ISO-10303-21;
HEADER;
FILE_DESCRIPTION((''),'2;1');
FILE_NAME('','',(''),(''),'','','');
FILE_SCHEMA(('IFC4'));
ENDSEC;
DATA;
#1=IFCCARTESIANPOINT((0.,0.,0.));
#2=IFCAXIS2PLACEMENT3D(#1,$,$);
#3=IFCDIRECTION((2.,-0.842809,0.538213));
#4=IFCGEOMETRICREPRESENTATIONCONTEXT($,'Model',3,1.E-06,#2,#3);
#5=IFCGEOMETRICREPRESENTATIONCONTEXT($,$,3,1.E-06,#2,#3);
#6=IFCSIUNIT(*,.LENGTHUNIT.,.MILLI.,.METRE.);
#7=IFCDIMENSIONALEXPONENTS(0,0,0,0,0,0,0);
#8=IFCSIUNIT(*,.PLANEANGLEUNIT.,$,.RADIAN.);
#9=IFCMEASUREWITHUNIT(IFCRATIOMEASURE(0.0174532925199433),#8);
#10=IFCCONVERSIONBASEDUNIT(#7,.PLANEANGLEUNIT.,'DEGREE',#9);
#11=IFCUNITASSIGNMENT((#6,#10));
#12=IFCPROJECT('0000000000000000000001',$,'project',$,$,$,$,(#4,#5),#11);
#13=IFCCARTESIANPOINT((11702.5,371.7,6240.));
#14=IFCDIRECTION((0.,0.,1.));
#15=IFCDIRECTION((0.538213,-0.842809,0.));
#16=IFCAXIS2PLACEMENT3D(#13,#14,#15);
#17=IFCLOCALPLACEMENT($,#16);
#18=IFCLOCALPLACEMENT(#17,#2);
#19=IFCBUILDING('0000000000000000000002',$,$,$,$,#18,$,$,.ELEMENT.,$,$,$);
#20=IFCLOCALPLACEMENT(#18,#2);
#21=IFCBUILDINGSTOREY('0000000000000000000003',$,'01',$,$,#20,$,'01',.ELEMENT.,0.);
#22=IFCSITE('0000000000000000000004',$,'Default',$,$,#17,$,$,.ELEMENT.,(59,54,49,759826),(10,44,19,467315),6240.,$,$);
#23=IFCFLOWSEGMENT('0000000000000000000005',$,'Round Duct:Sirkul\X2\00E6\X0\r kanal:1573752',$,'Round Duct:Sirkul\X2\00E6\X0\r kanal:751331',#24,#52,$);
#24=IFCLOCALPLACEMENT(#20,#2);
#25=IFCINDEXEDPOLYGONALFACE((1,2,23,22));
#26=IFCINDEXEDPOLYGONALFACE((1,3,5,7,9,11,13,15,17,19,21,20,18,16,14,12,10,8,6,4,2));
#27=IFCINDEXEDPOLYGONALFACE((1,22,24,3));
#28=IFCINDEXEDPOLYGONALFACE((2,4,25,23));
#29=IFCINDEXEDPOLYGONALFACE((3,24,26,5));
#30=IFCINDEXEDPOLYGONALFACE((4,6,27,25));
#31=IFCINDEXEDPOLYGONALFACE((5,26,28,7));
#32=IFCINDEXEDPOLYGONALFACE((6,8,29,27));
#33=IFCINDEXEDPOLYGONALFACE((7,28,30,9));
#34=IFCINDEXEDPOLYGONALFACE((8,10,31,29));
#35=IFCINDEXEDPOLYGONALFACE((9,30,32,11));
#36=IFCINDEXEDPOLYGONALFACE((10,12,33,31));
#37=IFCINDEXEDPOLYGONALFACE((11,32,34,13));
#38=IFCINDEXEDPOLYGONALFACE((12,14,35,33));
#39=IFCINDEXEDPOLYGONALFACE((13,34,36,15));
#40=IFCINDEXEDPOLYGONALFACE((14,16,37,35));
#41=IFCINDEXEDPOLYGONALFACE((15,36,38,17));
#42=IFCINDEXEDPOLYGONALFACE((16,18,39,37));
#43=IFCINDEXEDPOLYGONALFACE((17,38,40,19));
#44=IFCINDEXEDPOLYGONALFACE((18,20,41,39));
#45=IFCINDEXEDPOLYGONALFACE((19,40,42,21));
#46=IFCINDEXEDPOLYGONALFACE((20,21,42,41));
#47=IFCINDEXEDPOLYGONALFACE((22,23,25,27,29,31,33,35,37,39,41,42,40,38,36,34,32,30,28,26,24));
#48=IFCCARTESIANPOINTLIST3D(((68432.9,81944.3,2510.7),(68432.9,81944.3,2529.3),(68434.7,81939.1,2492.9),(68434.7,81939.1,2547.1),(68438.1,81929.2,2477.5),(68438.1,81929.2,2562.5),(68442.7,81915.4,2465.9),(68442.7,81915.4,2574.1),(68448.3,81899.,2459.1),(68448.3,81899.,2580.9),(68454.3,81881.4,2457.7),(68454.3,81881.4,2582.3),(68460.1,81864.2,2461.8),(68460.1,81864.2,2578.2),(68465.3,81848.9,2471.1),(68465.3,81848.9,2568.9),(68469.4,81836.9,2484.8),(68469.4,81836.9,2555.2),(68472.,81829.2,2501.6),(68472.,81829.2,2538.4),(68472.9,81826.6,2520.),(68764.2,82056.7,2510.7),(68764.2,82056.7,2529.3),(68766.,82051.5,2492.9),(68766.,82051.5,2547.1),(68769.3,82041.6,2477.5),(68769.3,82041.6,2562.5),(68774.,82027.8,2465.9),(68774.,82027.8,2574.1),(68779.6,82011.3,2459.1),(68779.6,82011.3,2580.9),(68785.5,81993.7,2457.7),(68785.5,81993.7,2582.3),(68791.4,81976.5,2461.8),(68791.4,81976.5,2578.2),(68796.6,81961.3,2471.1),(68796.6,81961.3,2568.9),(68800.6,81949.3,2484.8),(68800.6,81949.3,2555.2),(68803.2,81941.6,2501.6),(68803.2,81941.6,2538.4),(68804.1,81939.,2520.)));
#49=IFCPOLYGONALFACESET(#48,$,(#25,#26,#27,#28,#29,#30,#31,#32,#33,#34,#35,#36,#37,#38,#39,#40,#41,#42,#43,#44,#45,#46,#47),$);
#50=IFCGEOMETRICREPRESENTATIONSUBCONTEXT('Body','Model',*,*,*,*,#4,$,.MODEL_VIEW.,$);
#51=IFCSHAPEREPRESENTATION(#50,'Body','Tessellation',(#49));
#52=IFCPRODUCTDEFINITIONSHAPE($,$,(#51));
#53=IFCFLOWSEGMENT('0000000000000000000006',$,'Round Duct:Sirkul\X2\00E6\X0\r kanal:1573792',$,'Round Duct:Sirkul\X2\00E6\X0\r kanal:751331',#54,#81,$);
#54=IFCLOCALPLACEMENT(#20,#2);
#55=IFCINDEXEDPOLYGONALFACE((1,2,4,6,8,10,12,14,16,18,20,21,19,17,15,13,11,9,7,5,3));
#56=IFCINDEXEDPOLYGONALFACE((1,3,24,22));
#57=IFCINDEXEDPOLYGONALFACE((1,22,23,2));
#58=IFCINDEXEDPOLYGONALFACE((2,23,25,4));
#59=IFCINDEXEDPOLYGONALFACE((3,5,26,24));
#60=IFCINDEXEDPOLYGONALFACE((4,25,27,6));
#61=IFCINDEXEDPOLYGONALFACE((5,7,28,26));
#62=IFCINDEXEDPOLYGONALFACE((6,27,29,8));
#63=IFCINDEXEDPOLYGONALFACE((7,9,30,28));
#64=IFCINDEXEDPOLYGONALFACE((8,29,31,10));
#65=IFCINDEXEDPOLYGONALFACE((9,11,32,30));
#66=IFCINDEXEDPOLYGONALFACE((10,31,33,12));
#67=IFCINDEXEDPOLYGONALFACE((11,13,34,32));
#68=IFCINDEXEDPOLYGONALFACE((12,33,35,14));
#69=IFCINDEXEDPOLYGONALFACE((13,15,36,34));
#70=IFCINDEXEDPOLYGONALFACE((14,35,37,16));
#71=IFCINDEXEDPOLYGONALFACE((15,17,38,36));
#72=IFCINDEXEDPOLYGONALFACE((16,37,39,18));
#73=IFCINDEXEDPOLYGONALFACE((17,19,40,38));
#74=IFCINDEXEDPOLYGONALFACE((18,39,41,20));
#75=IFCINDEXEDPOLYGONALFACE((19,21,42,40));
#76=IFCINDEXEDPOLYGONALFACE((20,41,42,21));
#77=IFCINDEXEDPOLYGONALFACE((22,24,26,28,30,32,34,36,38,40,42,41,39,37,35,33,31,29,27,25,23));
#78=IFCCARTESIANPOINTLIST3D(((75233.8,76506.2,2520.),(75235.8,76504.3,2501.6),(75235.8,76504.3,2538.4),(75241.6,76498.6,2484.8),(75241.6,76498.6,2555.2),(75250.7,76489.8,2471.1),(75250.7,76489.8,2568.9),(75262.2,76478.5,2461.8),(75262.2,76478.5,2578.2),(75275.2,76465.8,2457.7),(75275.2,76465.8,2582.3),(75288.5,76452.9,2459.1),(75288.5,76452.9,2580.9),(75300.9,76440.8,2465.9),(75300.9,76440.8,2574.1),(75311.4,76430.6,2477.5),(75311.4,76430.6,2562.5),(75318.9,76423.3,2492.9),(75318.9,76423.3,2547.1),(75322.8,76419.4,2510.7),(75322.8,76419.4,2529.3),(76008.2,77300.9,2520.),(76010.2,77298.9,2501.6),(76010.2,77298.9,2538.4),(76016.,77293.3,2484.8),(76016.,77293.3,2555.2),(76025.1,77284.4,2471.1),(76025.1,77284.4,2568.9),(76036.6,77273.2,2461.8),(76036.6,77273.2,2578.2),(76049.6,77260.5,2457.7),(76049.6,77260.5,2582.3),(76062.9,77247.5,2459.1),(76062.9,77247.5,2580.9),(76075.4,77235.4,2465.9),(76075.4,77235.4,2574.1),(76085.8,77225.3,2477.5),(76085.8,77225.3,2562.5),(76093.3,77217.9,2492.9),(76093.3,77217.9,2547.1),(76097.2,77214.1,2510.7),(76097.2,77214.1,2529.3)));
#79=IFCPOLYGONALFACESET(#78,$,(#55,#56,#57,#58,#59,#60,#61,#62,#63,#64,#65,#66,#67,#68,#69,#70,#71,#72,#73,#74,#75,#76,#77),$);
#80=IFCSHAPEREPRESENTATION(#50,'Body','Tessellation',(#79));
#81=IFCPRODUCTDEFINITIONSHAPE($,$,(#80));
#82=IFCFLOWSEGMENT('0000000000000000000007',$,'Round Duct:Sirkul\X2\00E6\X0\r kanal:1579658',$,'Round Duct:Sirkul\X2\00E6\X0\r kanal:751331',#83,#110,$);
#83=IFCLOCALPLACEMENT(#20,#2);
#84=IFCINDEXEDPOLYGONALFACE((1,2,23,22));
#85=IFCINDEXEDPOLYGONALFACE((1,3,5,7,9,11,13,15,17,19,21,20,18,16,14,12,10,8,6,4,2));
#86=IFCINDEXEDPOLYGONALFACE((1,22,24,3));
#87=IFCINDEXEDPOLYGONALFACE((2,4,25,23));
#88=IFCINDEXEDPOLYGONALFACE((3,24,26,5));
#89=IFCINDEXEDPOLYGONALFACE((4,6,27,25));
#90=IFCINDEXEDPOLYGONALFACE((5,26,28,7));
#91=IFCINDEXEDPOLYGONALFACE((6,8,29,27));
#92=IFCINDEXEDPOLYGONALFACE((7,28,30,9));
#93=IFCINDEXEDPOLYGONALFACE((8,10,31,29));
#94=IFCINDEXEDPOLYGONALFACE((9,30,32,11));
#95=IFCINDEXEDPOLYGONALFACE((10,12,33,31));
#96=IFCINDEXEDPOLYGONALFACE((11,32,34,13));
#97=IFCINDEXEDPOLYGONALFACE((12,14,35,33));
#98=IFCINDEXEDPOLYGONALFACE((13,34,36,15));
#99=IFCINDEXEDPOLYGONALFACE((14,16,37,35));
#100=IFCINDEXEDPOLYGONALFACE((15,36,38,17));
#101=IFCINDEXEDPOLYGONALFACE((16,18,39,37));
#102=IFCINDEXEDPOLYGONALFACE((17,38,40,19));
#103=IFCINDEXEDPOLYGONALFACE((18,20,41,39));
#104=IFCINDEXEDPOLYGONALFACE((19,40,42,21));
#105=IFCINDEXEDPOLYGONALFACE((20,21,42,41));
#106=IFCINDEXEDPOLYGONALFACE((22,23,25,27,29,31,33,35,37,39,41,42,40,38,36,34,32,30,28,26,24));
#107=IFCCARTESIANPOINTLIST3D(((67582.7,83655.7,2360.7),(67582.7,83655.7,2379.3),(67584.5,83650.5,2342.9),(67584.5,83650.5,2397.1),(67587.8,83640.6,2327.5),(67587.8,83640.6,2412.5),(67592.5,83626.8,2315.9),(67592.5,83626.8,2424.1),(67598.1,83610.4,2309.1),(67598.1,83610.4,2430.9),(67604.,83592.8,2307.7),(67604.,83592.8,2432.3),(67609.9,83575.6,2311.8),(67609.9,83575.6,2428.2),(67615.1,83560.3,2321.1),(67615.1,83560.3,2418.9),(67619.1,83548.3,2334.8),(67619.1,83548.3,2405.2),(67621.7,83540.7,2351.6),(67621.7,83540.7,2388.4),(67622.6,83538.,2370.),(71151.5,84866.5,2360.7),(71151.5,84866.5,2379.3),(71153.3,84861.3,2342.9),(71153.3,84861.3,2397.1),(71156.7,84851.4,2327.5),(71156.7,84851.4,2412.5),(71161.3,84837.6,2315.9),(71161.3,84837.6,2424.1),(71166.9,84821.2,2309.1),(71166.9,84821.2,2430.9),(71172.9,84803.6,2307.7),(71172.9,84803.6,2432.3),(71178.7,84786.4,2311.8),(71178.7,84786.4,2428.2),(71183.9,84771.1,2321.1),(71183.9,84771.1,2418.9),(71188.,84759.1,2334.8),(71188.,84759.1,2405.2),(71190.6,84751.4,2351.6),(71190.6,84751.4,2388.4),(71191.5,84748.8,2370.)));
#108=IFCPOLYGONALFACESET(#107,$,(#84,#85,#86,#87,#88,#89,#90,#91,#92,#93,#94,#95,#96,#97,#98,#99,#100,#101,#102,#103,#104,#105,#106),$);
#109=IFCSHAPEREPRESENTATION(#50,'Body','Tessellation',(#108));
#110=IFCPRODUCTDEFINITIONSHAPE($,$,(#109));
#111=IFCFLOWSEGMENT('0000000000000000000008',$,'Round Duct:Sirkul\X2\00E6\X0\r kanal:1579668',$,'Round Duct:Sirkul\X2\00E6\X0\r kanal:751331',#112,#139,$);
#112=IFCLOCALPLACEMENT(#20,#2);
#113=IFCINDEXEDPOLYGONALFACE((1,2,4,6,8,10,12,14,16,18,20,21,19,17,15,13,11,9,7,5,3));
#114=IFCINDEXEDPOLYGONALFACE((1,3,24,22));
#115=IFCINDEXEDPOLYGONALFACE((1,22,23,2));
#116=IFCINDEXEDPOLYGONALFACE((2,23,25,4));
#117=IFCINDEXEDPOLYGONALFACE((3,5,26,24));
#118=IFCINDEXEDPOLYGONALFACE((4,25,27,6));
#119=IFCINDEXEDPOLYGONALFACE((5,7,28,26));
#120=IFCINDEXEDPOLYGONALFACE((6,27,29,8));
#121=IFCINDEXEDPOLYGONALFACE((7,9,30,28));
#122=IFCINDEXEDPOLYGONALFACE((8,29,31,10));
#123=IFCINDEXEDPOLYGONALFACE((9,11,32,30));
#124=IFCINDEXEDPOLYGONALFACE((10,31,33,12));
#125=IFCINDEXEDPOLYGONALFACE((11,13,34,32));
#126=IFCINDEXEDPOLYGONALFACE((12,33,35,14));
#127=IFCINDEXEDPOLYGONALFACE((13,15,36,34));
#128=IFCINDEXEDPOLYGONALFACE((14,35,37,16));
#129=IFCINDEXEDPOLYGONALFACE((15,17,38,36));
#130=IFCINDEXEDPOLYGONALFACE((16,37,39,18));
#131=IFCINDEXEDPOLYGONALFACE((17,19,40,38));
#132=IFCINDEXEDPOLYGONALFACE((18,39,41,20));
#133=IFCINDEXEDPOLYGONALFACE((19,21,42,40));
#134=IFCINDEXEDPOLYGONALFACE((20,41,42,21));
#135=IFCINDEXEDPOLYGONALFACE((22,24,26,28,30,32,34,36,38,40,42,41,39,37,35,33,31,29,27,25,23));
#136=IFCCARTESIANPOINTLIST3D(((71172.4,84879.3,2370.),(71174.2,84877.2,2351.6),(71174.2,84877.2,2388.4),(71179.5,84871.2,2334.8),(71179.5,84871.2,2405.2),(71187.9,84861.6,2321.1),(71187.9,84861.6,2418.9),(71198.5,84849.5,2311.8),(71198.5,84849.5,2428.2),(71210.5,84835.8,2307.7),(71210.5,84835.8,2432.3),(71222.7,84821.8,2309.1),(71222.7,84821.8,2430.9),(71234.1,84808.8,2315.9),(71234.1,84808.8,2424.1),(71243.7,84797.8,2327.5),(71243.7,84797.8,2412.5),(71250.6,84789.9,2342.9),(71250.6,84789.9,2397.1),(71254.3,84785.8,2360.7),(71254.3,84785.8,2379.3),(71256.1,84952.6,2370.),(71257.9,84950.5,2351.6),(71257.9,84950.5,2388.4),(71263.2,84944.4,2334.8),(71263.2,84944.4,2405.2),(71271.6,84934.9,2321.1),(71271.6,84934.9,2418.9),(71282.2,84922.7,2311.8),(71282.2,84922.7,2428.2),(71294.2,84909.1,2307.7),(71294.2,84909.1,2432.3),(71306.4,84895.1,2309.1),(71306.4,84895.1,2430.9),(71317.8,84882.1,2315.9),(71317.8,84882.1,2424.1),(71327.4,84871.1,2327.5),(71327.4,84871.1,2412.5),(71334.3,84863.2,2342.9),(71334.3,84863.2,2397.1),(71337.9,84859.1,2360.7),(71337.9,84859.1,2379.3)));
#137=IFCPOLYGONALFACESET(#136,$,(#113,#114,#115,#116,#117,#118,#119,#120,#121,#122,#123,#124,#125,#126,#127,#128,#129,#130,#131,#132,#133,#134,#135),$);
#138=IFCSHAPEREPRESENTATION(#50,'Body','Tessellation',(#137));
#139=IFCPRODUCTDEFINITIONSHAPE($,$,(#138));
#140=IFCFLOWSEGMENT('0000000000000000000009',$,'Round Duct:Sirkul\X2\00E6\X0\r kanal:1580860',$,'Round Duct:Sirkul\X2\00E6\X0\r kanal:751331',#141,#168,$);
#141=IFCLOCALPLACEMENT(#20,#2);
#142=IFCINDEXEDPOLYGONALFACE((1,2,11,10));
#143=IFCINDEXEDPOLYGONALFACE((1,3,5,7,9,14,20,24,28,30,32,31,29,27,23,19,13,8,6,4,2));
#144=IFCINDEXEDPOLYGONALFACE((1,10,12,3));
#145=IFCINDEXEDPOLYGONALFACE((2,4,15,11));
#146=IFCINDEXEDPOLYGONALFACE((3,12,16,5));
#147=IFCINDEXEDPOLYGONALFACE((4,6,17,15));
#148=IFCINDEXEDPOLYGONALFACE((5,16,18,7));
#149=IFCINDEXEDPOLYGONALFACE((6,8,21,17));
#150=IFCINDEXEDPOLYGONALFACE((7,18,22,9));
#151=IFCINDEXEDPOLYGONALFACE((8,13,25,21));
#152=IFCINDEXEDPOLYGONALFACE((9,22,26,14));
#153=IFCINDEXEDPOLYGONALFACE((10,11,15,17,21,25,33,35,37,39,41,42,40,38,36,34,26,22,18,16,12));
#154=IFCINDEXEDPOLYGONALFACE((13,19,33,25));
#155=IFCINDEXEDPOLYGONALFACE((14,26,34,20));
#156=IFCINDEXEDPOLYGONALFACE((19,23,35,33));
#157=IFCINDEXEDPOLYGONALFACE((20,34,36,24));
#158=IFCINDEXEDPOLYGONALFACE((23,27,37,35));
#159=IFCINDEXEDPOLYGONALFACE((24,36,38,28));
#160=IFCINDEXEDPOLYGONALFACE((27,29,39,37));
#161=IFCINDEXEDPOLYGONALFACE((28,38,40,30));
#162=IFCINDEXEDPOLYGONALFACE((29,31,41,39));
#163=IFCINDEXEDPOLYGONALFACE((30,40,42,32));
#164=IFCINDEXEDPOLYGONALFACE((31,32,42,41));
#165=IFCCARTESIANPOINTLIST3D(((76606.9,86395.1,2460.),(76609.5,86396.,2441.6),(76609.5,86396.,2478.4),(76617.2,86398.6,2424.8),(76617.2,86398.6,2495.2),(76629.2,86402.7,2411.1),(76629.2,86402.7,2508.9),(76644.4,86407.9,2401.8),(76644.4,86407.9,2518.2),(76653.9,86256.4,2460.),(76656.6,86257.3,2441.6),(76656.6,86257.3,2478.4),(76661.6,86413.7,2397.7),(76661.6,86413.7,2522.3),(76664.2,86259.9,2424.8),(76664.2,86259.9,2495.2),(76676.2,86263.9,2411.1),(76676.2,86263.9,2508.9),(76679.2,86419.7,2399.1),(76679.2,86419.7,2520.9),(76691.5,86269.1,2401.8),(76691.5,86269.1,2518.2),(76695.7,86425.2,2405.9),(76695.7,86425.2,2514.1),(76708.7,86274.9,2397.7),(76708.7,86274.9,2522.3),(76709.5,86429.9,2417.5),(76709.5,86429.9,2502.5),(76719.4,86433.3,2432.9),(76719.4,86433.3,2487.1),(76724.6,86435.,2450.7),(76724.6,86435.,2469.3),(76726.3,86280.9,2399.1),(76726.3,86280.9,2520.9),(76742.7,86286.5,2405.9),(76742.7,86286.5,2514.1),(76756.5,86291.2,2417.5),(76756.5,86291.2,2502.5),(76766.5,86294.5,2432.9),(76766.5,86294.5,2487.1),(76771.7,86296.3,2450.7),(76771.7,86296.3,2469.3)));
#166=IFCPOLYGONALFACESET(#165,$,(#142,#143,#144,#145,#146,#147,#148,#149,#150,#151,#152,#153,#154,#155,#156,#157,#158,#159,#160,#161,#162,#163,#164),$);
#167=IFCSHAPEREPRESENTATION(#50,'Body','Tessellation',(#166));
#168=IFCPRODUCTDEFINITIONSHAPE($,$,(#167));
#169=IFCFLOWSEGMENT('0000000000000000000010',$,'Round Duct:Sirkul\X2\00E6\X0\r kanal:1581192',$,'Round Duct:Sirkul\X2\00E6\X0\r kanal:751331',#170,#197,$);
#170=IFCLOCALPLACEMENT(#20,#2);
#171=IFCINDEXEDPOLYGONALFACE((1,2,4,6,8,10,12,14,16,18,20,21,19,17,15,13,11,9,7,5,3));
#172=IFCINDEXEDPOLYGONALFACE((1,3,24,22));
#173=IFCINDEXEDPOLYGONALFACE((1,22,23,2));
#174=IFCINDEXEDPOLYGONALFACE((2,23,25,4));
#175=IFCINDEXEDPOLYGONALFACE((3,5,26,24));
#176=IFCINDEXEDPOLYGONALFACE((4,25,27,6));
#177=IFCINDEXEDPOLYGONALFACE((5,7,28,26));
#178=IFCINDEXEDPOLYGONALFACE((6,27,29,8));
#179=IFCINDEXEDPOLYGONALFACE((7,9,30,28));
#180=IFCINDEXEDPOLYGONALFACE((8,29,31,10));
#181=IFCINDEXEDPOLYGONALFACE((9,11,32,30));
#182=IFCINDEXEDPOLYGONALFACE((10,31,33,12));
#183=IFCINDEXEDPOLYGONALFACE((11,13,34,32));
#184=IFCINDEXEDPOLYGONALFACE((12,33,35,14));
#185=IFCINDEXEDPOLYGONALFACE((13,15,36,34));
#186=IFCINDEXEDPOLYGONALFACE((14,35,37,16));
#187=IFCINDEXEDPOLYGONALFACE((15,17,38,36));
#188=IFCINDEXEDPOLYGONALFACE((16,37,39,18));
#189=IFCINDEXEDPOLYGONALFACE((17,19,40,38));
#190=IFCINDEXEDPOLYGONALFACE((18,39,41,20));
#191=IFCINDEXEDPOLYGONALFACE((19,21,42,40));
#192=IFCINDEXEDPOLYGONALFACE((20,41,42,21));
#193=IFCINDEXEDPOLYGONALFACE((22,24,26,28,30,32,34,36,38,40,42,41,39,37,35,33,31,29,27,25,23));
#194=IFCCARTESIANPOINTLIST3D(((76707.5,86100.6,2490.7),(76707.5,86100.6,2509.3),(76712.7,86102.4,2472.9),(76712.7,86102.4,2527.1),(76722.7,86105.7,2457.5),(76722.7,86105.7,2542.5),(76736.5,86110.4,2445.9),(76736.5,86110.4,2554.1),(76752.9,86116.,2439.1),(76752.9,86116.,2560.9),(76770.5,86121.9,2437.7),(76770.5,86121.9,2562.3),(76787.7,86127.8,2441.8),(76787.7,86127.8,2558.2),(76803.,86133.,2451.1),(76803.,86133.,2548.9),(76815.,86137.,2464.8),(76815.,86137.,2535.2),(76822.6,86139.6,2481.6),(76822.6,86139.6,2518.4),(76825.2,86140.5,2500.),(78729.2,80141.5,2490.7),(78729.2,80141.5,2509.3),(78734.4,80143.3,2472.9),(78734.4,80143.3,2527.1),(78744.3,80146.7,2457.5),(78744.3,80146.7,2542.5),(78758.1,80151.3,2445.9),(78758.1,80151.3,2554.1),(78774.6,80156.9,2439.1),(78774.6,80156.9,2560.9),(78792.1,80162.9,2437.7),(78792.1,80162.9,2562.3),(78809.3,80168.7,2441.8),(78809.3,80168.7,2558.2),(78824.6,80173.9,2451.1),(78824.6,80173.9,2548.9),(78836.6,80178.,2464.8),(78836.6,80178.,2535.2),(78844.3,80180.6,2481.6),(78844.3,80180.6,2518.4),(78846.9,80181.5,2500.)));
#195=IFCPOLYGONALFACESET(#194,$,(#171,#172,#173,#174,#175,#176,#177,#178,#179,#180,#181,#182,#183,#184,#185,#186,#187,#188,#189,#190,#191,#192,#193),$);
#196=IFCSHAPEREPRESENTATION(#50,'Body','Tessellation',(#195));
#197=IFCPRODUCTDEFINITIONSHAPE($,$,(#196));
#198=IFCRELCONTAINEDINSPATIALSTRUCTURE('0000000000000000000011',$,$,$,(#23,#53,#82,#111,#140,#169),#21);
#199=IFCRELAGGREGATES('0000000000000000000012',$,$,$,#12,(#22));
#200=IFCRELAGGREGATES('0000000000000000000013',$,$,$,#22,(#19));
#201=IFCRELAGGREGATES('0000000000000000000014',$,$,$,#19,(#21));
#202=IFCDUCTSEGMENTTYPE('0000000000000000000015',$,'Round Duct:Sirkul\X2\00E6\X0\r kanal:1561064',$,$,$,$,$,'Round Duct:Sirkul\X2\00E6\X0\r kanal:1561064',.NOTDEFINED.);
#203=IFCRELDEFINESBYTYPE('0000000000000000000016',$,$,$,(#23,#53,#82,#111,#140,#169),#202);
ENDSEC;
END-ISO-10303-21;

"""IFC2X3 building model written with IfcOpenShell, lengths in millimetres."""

from ifc_helpers import new_model, entity, si_unit, converted_unit, direction, frame, frame_2d, origin, origin_2d_with_axis, place, context, subcontext, project, spatial, circle, extrude, type_object, element, save


model = new_model("IFC2X3")

# Units and contexts
model_context = context("Model", 3, precision=1e-06, world=origin(), true_north=direction((2.0, -0.842809, 0.538213)))
context_of_model = context(None, 3, precision=1e-06, world=origin(), true_north=direction((2.0, -0.842809, 0.538213)))
body_context = subcontext(model_context, "Body", "Model", "MODEL_VIEW")
ifc_project = project(units=[si_unit("LENGTHUNIT", "METRE", prefix="MILLI"), converted_unit("PLANEANGLEUNIT", "DEGREE", entity("IfcRatioMeasure", 0.0174532925199433), si_unit("PLANEANGLEUNIT", "RADIAN"), dimensions=[0, 0, 0, 0, 0, 0, 0])], contexts=[model_context, context_of_model])

# Site, building, storey
site_placement = place(None, frame((11702.5, 371.7, 6240.0), z_axis=(0.0, 0.0, 1.0), x_axis=(0.538213, -0.842809, 0.0)))
site = spatial("IfcSite", under=ifc_project, at=site_placement, Name="Default", CompositionType="ELEMENT", RefLatitude=(59, 54, 49, 759826), RefLongitude=(10, 44, 19, 467315), RefElevation=6240.0)
building_placement = place(site_placement, origin())
building = spatial("IfcBuilding", under=site, at=building_placement, CompositionType="ELEMENT")
storey_placement = place(building_placement, origin())
storey = spatial("IfcBuildingStorey", under=building, at=storey_placement, Name="01", LongName="01", CompositionType="ELEMENT", Elevation=0.0)

# Flow segments
duct_segment_type = type_object("IfcDuctSegmentType", Name="Round Duct:Sirkulær kanal:1561064", ElementType="Round Duct:Sirkulær kanal:1561064", PredefinedType="NOTDEFINED")
flow_segment_1_placement = place(storey_placement, origin())
element("IfcFlowSegment", 1, at=flow_segment_1_placement, inside=storey, type_object=duct_segment_type, Name="Round Duct:Sirkulær kanal:1573752", ObjectType="Round Duct:Sirkulær kanal:751331", context=body_context, shape_type="SweptSolid", body=[
    extrude(circle(Radius=62.5, at=origin_2d_with_axis()), frame((68452.8, 81885.8, 2520.0), z_axis=(0.946986, 0.321274, 0.0), x_axis=(0.321274, -0.946986, 0.0)), (0.0, 0.0, 1.0), 349.8),
])
flow_segment_2_placement = place(storey_placement, origin())
element("IfcFlowSegment", 2, at=flow_segment_2_placement, inside=storey, type_object=duct_segment_type, Name="Round Duct:Sirkulær kanal:1573792", ObjectType="Round Duct:Sirkulær kanal:751331", context=body_context, shape_type="SweptSolid", body=[
    extrude(circle(Radius=62.5, at=origin_2d_with_axis()), frame((75278.6, 76462.6, 2520.0), z_axis=(0.697915, 0.71618, 0.0), x_axis=(-0.71618, 0.697915, 0.0)), (0.0, 0.0, 1.0), 1109.6),
])
flow_segment_3_placement = place(storey_placement, origin())
element("IfcFlowSegment", 3, at=flow_segment_3_placement, inside=storey, type_object=duct_segment_type, Name="Round Duct:Sirkulær kanal:1579658", ObjectType="Round Duct:Sirkulær kanal:751331", context=body_context, shape_type="SweptSolid", body=[
    extrude(circle(Radius=62.5, at=origin_2d_with_axis()), frame((67602.5, 83597.2, 2370.0), z_axis=(0.946986, 0.321274, 0.0), x_axis=(0.321274, -0.946986, 0.0)), (0.0, 0.0, 1.0), 3768.6),
])
flow_segment_4_placement = place(storey_placement, origin())
element("IfcFlowSegment", 4, at=flow_segment_4_placement, inside=storey, type_object=duct_segment_type, Name="Round Duct:Sirkulær kanal:1579668", ObjectType="Round Duct:Sirkulær kanal:751331", context=body_context, shape_type="SweptSolid", body=[
    extrude(circle(Radius=62.5, at=frame_2d((0.0, 0.0), x_axis=(1.0, 0.0))), frame((71213.5, 84832.3, 2370.0), z_axis=(0.752413, 0.658691, 0.0), x_axis=(-0.658691, 0.752413, 0.0)), (0.0, 0.0, 1.0), 111.2),
])
flow_segment_5_placement = place(storey_placement, origin())
element("IfcFlowSegment", 5, at=flow_segment_5_placement, inside=storey, type_object=duct_segment_type, Name="Round Duct:Sirkulær kanal:1580860", ObjectType="Round Duct:Sirkulær kanal:751331", context=body_context, shape_type="SweptSolid", body=[
    extrude(circle(Radius=62.5, at=origin_2d_with_axis()), frame((76713.1, 86276.4, 2460.0), z_axis=(-0.321244, 0.946996, 0.0), x_axis=(-0.946996, -0.321244, 0.0)), (0.0, 0.0, 1.0), 146.5),
])
flow_segment_6_placement = place(storey_placement, origin())
element("IfcFlowSegment", 6, at=flow_segment_6_placement, inside=storey, type_object=duct_segment_type, Name="Round Duct:Sirkulær kanal:1581192", ObjectType="Round Duct:Sirkulær kanal:751331", context=body_context, shape_type="SweptSolid", body=[
    extrude(circle(Radius=62.5, at=origin_2d_with_axis()), frame((78787.7, 80161.4, 2500.0), z_axis=(-0.321274, 0.946986, 0.0), x_axis=(0.946986, 0.321274, 0.0)), (0.0, 0.0, 1.0), 6292.7),
])

save(model, "model.ifc")
